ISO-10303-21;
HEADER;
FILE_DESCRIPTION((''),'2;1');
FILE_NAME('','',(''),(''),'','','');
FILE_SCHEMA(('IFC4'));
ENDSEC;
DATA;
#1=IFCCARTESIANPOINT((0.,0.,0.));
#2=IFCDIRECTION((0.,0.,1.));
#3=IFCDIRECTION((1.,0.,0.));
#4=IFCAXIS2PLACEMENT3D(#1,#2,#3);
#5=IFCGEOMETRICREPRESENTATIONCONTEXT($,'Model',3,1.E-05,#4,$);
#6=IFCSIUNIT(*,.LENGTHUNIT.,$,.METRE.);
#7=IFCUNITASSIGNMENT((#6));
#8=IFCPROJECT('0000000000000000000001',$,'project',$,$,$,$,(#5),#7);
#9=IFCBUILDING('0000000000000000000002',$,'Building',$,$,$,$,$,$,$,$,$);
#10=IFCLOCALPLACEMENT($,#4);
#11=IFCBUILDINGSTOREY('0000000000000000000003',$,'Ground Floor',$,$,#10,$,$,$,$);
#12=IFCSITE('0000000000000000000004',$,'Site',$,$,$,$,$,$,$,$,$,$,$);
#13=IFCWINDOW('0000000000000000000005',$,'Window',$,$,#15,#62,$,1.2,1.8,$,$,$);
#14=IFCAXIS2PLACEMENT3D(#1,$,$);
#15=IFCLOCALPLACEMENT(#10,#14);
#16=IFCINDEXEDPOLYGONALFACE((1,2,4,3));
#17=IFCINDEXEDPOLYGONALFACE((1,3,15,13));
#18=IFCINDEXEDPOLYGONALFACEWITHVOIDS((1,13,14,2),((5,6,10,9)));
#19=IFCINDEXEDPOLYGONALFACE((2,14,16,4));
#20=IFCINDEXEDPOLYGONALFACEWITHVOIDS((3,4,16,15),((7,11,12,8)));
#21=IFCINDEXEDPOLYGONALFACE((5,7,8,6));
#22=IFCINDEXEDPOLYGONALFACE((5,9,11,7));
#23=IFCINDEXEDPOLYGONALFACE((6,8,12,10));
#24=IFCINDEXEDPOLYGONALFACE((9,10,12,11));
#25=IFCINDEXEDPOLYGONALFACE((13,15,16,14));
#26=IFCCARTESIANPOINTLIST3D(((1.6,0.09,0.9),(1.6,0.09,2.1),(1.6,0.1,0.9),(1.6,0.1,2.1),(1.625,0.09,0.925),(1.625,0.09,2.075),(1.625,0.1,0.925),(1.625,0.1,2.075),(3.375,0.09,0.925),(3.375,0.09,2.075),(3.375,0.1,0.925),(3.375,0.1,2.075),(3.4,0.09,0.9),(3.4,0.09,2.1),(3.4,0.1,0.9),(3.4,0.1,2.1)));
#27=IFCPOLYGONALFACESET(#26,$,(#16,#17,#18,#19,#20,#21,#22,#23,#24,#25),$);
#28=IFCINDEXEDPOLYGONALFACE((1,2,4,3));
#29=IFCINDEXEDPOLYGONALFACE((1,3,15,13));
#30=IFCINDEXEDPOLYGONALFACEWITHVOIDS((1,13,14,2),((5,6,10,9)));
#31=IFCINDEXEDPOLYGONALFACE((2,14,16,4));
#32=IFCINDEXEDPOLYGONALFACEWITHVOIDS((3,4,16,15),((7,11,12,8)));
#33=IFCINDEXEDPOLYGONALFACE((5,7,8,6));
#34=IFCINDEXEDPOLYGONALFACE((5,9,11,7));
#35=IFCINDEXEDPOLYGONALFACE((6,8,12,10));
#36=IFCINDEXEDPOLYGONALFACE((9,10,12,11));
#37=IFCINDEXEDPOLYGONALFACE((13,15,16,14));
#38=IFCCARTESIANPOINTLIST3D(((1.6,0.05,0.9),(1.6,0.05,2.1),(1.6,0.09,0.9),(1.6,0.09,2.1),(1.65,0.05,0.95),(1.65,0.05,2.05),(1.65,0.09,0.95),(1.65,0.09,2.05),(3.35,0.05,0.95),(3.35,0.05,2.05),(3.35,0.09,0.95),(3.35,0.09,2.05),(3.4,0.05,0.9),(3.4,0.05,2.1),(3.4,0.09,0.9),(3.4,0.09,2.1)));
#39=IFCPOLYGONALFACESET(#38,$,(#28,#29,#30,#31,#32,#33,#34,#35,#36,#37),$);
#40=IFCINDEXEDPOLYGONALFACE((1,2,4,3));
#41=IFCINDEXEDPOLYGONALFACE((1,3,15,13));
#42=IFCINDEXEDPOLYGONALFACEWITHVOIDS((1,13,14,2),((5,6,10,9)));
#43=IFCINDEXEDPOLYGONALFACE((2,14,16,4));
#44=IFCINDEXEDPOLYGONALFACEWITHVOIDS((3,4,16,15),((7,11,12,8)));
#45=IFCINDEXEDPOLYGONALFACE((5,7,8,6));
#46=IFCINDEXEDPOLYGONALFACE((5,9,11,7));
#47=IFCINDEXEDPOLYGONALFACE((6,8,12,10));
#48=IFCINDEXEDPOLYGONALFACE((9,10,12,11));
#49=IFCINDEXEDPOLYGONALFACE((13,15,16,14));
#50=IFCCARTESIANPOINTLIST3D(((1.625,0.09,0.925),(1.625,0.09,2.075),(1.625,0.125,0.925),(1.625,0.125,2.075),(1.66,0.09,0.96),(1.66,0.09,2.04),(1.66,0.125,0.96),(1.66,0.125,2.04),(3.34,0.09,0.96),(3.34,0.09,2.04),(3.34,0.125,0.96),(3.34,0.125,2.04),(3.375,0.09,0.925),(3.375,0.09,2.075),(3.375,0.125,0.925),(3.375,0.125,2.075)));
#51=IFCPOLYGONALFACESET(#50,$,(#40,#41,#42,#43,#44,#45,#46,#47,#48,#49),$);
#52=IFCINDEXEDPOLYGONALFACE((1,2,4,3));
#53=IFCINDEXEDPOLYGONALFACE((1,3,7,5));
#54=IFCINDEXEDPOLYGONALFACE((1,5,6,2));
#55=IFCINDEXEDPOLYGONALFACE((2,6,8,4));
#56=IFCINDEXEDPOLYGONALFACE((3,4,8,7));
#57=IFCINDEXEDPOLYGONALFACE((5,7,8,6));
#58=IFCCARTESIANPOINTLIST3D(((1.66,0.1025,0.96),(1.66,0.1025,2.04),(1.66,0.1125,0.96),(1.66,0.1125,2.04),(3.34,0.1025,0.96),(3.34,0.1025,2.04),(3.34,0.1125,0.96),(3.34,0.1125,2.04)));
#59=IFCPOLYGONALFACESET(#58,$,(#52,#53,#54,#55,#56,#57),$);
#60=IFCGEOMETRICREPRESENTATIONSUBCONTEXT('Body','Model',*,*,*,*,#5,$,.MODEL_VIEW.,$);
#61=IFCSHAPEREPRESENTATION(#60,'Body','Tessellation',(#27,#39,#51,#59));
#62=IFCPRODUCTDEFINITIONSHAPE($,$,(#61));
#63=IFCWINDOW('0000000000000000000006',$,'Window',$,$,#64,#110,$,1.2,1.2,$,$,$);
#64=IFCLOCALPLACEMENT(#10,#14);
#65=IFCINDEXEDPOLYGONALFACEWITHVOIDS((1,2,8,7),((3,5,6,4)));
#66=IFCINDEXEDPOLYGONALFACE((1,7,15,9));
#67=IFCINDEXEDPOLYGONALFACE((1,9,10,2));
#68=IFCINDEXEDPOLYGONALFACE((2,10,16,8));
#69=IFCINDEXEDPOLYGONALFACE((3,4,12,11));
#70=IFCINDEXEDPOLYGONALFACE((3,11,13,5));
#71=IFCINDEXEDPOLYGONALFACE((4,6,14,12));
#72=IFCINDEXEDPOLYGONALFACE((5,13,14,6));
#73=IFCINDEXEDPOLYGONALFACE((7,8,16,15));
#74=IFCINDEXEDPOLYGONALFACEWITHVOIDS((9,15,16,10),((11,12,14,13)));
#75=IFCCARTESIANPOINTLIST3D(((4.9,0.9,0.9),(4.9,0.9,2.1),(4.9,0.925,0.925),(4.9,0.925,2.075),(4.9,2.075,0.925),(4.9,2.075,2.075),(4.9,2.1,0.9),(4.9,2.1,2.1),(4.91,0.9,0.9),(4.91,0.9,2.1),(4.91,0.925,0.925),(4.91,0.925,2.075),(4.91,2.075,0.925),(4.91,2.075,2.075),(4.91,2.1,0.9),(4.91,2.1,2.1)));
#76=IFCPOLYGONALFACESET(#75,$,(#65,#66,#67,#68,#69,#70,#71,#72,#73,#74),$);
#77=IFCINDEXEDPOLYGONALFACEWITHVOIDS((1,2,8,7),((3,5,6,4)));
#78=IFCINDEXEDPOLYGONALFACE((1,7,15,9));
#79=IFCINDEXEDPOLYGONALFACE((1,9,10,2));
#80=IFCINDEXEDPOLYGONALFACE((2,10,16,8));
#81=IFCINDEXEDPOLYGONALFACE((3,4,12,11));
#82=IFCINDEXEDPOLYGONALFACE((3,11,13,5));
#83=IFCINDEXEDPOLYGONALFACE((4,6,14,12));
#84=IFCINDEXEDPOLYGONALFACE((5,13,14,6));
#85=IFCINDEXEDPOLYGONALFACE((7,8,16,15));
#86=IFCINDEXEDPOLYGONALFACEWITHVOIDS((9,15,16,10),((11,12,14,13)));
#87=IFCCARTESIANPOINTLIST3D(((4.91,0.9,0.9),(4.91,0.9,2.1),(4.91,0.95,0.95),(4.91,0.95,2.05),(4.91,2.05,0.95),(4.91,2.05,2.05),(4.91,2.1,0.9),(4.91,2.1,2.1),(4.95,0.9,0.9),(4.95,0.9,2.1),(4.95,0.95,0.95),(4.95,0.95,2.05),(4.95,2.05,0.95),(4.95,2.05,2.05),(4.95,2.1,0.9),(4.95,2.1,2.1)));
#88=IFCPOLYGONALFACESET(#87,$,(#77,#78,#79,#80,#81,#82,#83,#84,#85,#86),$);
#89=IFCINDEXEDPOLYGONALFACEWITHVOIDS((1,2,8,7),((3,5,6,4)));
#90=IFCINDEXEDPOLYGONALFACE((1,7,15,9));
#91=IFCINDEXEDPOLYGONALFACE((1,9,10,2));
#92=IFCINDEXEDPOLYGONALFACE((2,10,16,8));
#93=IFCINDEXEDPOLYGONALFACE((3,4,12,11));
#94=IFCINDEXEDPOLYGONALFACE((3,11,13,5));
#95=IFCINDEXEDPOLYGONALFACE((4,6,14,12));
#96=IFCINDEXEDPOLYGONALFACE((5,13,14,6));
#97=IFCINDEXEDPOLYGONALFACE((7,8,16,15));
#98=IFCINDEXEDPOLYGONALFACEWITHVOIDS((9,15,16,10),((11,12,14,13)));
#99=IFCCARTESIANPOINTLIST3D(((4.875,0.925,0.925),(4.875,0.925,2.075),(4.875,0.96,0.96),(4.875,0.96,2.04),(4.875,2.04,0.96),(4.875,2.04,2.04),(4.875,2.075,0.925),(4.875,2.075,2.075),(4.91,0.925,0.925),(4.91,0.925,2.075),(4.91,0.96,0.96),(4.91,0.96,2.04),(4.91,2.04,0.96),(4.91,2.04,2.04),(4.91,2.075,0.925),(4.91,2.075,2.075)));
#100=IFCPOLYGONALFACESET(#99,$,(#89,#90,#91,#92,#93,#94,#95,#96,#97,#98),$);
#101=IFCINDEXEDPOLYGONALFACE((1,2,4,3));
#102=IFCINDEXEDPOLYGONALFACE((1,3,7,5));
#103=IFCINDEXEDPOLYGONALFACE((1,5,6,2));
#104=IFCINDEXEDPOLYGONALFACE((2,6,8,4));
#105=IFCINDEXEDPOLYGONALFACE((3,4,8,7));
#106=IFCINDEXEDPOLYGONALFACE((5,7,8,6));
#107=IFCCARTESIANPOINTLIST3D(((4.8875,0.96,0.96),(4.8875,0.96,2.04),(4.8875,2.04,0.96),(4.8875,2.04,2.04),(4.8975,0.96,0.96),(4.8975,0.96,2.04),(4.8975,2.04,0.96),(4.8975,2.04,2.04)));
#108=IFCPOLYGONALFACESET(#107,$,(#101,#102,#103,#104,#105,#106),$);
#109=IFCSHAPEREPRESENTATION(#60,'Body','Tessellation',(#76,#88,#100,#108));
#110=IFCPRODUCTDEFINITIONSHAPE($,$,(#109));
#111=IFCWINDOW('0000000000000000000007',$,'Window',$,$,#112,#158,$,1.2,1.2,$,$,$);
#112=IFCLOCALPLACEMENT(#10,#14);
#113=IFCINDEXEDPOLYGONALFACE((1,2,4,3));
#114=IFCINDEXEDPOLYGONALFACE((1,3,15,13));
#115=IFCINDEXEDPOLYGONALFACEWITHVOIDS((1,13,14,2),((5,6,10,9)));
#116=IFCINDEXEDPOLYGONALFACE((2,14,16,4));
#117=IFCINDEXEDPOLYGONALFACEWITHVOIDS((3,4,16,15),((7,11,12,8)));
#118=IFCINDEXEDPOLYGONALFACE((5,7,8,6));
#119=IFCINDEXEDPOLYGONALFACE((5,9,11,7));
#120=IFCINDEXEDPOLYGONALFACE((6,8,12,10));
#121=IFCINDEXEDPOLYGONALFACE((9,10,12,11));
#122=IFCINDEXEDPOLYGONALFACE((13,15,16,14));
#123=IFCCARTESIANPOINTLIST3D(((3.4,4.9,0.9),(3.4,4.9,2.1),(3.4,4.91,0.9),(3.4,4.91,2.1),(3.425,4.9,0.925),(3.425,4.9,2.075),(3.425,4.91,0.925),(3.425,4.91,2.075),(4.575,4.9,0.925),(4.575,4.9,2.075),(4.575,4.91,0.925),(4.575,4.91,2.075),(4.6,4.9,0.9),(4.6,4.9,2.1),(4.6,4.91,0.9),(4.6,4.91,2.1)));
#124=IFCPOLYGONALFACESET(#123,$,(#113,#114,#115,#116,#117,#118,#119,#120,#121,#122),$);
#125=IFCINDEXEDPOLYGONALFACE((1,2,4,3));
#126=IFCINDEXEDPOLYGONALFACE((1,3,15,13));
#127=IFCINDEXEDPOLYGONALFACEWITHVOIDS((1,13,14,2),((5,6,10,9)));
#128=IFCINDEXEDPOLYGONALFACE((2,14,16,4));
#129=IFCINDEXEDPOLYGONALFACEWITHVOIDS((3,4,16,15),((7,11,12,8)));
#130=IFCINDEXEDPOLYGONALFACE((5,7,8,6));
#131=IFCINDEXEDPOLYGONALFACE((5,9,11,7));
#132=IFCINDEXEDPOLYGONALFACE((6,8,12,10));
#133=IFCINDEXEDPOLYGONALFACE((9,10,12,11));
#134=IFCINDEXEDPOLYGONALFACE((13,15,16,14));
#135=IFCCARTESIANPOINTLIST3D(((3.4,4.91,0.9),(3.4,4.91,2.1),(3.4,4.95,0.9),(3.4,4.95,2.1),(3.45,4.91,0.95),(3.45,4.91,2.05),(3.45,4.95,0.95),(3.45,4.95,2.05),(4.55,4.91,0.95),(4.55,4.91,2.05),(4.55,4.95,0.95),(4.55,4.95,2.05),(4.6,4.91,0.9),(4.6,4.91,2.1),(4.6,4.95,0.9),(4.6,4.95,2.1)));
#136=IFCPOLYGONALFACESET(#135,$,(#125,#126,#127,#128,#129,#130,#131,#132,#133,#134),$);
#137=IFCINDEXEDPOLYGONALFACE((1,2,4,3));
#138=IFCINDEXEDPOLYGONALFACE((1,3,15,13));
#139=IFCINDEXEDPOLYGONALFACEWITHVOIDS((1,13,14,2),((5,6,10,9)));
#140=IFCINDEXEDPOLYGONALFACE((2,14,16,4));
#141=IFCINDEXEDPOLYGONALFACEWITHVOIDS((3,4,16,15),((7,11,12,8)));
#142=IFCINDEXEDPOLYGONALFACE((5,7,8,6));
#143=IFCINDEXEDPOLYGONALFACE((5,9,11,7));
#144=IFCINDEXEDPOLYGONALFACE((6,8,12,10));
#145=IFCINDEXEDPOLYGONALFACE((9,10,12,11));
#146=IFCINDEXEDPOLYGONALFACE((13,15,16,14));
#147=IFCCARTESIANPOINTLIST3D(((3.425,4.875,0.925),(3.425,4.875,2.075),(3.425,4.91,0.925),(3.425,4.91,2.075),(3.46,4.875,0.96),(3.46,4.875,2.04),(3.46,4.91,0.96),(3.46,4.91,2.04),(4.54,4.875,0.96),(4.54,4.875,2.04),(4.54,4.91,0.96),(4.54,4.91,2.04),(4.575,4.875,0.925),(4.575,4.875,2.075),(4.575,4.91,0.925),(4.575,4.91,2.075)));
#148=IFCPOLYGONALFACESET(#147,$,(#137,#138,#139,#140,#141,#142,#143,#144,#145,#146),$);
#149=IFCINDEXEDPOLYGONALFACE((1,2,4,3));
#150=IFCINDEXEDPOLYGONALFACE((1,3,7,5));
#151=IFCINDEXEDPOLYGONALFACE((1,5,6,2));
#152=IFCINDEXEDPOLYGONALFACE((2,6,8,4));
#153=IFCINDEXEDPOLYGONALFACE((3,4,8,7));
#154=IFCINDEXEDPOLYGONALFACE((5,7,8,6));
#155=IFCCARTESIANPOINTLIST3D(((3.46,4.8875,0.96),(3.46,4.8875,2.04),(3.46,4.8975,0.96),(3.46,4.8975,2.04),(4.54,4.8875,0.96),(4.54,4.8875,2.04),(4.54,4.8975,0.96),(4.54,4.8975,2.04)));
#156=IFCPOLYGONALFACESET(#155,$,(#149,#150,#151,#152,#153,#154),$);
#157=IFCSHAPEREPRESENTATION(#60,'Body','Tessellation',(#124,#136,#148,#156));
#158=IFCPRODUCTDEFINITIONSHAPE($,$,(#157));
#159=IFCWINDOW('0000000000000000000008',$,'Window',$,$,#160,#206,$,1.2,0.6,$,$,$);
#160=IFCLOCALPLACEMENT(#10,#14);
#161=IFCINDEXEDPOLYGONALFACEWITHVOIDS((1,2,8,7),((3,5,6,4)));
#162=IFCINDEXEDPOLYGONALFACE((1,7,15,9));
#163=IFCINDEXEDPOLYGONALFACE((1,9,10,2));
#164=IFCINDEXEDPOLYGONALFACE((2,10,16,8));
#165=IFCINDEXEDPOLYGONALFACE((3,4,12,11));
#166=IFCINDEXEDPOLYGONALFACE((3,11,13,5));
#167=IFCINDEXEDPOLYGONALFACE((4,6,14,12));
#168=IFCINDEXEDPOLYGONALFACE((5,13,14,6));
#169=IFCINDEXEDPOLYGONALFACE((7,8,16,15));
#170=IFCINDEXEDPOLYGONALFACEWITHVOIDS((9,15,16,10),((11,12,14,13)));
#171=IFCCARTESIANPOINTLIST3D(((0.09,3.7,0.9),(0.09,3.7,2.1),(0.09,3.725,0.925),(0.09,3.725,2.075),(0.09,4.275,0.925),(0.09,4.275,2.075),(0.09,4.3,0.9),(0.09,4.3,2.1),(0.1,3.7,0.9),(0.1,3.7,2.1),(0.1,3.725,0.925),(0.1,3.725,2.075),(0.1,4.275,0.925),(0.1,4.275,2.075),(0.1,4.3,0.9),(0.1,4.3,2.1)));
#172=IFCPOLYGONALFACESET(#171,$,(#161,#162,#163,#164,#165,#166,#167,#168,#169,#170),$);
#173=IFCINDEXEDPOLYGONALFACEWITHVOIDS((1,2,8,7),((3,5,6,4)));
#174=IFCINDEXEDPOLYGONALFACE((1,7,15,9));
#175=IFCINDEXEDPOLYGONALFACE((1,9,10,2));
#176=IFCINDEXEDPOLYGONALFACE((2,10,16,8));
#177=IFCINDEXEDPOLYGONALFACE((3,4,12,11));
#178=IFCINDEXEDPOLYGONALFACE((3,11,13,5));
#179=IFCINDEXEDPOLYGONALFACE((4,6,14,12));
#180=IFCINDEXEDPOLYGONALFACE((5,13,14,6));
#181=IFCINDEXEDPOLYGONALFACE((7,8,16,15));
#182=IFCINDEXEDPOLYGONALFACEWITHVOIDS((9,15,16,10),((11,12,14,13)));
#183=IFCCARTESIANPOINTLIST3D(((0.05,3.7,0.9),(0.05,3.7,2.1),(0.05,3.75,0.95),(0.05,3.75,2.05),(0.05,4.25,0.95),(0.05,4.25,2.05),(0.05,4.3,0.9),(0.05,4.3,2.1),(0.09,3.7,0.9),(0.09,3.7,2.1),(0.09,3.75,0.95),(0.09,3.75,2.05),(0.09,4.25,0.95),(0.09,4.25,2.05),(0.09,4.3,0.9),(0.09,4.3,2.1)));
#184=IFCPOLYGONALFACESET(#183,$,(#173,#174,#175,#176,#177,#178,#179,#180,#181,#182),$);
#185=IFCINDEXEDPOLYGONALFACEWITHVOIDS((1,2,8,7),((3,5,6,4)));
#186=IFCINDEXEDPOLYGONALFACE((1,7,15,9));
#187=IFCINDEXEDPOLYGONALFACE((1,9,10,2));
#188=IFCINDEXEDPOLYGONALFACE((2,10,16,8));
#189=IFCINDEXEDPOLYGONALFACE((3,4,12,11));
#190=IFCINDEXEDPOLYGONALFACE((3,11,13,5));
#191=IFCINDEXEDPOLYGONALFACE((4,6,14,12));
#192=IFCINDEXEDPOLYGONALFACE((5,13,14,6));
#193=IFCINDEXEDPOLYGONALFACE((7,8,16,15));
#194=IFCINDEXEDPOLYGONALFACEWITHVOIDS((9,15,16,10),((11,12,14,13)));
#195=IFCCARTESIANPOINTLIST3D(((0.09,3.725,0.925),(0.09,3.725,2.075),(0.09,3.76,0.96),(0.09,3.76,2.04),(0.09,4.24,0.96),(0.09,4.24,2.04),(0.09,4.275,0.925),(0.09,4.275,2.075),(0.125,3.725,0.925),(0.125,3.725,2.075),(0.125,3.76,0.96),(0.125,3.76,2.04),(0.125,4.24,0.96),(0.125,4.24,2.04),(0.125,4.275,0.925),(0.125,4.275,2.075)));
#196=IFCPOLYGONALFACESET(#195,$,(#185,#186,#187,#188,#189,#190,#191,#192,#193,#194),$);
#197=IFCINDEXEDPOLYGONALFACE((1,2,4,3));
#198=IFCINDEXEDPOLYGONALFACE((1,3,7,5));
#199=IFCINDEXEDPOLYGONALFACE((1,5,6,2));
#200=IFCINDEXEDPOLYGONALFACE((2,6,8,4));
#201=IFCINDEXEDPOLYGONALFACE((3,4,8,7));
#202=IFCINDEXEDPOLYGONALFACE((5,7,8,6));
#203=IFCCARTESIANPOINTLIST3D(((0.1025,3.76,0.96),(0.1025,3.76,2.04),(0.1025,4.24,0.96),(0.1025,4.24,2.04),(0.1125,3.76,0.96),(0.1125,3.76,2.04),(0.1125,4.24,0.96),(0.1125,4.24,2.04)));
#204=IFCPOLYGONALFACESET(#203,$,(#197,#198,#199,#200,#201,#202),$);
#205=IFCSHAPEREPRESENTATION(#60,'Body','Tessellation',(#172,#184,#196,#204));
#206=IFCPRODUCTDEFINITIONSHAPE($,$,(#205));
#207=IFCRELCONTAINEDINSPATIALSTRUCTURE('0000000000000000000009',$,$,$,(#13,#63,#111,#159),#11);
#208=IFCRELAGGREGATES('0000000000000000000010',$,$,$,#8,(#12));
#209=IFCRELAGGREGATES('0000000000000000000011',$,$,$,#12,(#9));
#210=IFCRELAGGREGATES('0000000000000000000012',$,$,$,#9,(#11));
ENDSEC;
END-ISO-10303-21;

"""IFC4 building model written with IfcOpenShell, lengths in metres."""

from ifc_helpers import new_model, si_unit, frame, origin_with_axes, place, context, subcontext, project, spatial, line, indexed_curve, outline, extrude, element, save


model = new_model("IFC4")

# Units and contexts
model_context = context("Model", 3, precision=1e-05, world=origin_with_axes())
body_context = subcontext(model_context, "Body", "Model", "MODEL_VIEW")
ifc_project = project(units=[si_unit("LENGTHUNIT", "METRE")], contexts=[model_context])

# Site, building, storey
site = spatial("IfcSite", under=ifc_project, Name="Site")
building = spatial("IfcBuilding", under=site, Name="Building")
storey_placement = place(None, origin_with_axes())
storey = spatial("IfcBuildingStorey", under=building, at=storey_placement, Name="Ground Floor")

# Windows
window_1_placement = place(storey_placement, frame((1.6, 0.0, 0.9), z_axis=(0.0, 0.0, 1.0), x_axis=(1.0, 0.0, 0.0)))
element("IfcWindow", 1, at=window_1_placement, inside=storey, Name="Window", OverallHeight=1.2, OverallWidth=1.8, context=body_context, shape_type="SweptSolid", body=[
    extrude(outline(indexed_curve([(0.0, 0.0), (1.8, 0.0), (1.8, 1.2), (0.0, 1.2)], segments=[line(1, 2, 3, 4, 1)]), holes=[indexed_curve([(0.025, 0.025), (1.775, 0.025), (1.775, 1.175), (0.025, 1.175)], segments=[line(1, 2, 3, 4, 1)])]), frame((0.0, 0.09, 0.0), z_axis=(0.0, -1.0, 0.0), x_axis=(1.0, 0.0, 0.0)), (0.0, 0.0, -1.0), 0.01),
    extrude(outline(indexed_curve([(0.0, 0.0), (1.8, 0.0), (1.8, 1.2), (0.0, 1.2)], segments=[line(1, 2, 3, 4, 1)]), holes=[indexed_curve([(0.05, 0.05), (1.75, 0.05), (1.75, 1.15), (0.05, 1.15)], segments=[line(1, 2, 3, 4, 1)])]), frame((0.0, 0.05, 0.0), z_axis=(0.0, -1.0, 0.0), x_axis=(1.0, 0.0, 0.0)), (0.0, 0.0, -1.0), 0.04),
    extrude(outline(indexed_curve([(0.0, 0.0), (1.75, 0.0), (1.75, 1.15), (0.0, 1.15)], segments=[line(1, 2, 3, 4, 1)]), holes=[indexed_curve([(0.035, 0.035), (1.715, 0.035), (1.715, 1.115), (0.035, 1.115)], segments=[line(1, 2, 3, 4, 1)])]), frame((0.025, 0.09, 0.025), z_axis=(0.0, -1.0, 0.0), x_axis=(1.0, 0.0, 0.0)), (0.0, 0.0, -1.0), 0.035),
    extrude(outline(indexed_curve([(0.035, 0.035), (1.715, 0.035), (1.715, 1.115), (0.035, 1.115)], segments=[line(1, 2, 3, 4, 1)])), frame((0.025, 0.1025, 0.025), z_axis=(0.0, -1.0, 0.0), x_axis=(1.0, 0.0, 0.0)), (0.0, 0.0, -1.0), 0.01),
])
for number, where, z_axis, x_axis, name in (
    (2, (5.0, 0.9, 0.9), (0.0, 0.0, 1.0), (0.0, 1.0, 0.0), "Window"),
    (3, (4.6, 5.0, 0.9), (0.0, 0.0, 1.0), (-1.0, 0.0, 0.0), "Window"),
):
    element("IfcWindow", number, at=place(storey_placement, frame(where, z_axis=z_axis, x_axis=x_axis)), inside=storey, Name=name, OverallHeight=1.2, OverallWidth=1.2, context=body_context, shape_type="SweptSolid", body=[
        extrude(outline(indexed_curve([(0.0, 0.0), (1.2, 0.0), (1.2, 1.2), (0.0, 1.2)], segments=[line(1, 2, 3, 4, 1)]), holes=[indexed_curve([(0.025, 0.025), (1.175, 0.025), (1.175, 1.175), (0.025, 1.175)], segments=[line(1, 2, 3, 4, 1)])]), frame((0.0, 0.09, 0.0), z_axis=(0.0, -1.0, 0.0), x_axis=(1.0, 0.0, 0.0)), (0.0, 0.0, -1.0), 0.01),
        extrude(outline(indexed_curve([(0.0, 0.0), (1.2, 0.0), (1.2, 1.2), (0.0, 1.2)], segments=[line(1, 2, 3, 4, 1)]), holes=[indexed_curve([(0.05, 0.05), (1.15, 0.05), (1.15, 1.15), (0.05, 1.15)], segments=[line(1, 2, 3, 4, 1)])]), frame((0.0, 0.05, 0.0), z_axis=(0.0, -1.0, 0.0), x_axis=(1.0, 0.0, 0.0)), (0.0, 0.0, -1.0), 0.04),
        extrude(outline(indexed_curve([(0.0, 0.0), (1.15, 0.0), (1.15, 1.15), (0.0, 1.15)], segments=[line(1, 2, 3, 4, 1)]), holes=[indexed_curve([(0.035, 0.035), (1.115, 0.035), (1.115, 1.115), (0.035, 1.115)], segments=[line(1, 2, 3, 4, 1)])]), frame((0.025, 0.09, 0.025), z_axis=(0.0, -1.0, 0.0), x_axis=(1.0, 0.0, 0.0)), (0.0, 0.0, -1.0), 0.035),
        extrude(outline(indexed_curve([(0.035, 0.035), (1.115, 0.035), (1.115, 1.115), (0.035, 1.115)], segments=[line(1, 2, 3, 4, 1)])), frame((0.025, 0.1025, 0.025), z_axis=(0.0, -1.0, 0.0), x_axis=(1.0, 0.0, 0.0)), (0.0, 0.0, -1.0), 0.01),
    ])
window_2_placement = place(storey_placement, frame((0.0, 4.3, 0.9), z_axis=(0.0, 0.0, 1.0), x_axis=(0.0, -1.0, 0.0)))
element("IfcWindow", 4, at=window_2_placement, inside=storey, Name="Window", OverallHeight=1.2, OverallWidth=0.6, context=body_context, shape_type="SweptSolid", body=[
    extrude(outline(indexed_curve([(0.0, 0.0), (0.6, 0.0), (0.6, 1.2), (0.0, 1.2)], segments=[line(1, 2, 3, 4, 1)]), holes=[indexed_curve([(0.025, 0.025), (0.575, 0.025), (0.575, 1.175), (0.025, 1.175)], segments=[line(1, 2, 3, 4, 1)])]), frame((0.0, 0.09, 0.0), z_axis=(0.0, -1.0, 0.0), x_axis=(1.0, 0.0, 0.0)), (0.0, 0.0, -1.0), 0.01),
    extrude(outline(indexed_curve([(0.0, 0.0), (0.6, 0.0), (0.6, 1.2), (0.0, 1.2)], segments=[line(1, 2, 3, 4, 1)]), holes=[indexed_curve([(0.05, 0.05), (0.55, 0.05), (0.55, 1.15), (0.05, 1.15)], segments=[line(1, 2, 3, 4, 1)])]), frame((0.0, 0.05, 0.0), z_axis=(0.0, -1.0, 0.0), x_axis=(1.0, 0.0, 0.0)), (0.0, 0.0, -1.0), 0.04),
    extrude(outline(indexed_curve([(0.0, 0.0), (0.55, 0.0), (0.55, 1.15), (0.0, 1.15)], segments=[line(1, 2, 3, 4, 1)]), holes=[indexed_curve([(0.035, 0.035), (0.515, 0.035), (0.515, 1.115), (0.035, 1.115)], segments=[line(1, 2, 3, 4, 1)])]), frame((0.025, 0.09, 0.025), z_axis=(0.0, -1.0, 0.0), x_axis=(1.0, 0.0, 0.0)), (0.0, 0.0, -1.0), 0.035),
    extrude(outline(indexed_curve([(0.035, 0.035), (0.515, 0.035), (0.515, 1.115), (0.035, 1.115)], segments=[line(1, 2, 3, 4, 1)])), frame((0.025, 0.1025, 0.025), z_axis=(0.0, -1.0, 0.0), x_axis=(1.0, 0.0, 0.0)), (0.0, 0.0, -1.0), 0.01),
])

save(model, "model.ifc")
